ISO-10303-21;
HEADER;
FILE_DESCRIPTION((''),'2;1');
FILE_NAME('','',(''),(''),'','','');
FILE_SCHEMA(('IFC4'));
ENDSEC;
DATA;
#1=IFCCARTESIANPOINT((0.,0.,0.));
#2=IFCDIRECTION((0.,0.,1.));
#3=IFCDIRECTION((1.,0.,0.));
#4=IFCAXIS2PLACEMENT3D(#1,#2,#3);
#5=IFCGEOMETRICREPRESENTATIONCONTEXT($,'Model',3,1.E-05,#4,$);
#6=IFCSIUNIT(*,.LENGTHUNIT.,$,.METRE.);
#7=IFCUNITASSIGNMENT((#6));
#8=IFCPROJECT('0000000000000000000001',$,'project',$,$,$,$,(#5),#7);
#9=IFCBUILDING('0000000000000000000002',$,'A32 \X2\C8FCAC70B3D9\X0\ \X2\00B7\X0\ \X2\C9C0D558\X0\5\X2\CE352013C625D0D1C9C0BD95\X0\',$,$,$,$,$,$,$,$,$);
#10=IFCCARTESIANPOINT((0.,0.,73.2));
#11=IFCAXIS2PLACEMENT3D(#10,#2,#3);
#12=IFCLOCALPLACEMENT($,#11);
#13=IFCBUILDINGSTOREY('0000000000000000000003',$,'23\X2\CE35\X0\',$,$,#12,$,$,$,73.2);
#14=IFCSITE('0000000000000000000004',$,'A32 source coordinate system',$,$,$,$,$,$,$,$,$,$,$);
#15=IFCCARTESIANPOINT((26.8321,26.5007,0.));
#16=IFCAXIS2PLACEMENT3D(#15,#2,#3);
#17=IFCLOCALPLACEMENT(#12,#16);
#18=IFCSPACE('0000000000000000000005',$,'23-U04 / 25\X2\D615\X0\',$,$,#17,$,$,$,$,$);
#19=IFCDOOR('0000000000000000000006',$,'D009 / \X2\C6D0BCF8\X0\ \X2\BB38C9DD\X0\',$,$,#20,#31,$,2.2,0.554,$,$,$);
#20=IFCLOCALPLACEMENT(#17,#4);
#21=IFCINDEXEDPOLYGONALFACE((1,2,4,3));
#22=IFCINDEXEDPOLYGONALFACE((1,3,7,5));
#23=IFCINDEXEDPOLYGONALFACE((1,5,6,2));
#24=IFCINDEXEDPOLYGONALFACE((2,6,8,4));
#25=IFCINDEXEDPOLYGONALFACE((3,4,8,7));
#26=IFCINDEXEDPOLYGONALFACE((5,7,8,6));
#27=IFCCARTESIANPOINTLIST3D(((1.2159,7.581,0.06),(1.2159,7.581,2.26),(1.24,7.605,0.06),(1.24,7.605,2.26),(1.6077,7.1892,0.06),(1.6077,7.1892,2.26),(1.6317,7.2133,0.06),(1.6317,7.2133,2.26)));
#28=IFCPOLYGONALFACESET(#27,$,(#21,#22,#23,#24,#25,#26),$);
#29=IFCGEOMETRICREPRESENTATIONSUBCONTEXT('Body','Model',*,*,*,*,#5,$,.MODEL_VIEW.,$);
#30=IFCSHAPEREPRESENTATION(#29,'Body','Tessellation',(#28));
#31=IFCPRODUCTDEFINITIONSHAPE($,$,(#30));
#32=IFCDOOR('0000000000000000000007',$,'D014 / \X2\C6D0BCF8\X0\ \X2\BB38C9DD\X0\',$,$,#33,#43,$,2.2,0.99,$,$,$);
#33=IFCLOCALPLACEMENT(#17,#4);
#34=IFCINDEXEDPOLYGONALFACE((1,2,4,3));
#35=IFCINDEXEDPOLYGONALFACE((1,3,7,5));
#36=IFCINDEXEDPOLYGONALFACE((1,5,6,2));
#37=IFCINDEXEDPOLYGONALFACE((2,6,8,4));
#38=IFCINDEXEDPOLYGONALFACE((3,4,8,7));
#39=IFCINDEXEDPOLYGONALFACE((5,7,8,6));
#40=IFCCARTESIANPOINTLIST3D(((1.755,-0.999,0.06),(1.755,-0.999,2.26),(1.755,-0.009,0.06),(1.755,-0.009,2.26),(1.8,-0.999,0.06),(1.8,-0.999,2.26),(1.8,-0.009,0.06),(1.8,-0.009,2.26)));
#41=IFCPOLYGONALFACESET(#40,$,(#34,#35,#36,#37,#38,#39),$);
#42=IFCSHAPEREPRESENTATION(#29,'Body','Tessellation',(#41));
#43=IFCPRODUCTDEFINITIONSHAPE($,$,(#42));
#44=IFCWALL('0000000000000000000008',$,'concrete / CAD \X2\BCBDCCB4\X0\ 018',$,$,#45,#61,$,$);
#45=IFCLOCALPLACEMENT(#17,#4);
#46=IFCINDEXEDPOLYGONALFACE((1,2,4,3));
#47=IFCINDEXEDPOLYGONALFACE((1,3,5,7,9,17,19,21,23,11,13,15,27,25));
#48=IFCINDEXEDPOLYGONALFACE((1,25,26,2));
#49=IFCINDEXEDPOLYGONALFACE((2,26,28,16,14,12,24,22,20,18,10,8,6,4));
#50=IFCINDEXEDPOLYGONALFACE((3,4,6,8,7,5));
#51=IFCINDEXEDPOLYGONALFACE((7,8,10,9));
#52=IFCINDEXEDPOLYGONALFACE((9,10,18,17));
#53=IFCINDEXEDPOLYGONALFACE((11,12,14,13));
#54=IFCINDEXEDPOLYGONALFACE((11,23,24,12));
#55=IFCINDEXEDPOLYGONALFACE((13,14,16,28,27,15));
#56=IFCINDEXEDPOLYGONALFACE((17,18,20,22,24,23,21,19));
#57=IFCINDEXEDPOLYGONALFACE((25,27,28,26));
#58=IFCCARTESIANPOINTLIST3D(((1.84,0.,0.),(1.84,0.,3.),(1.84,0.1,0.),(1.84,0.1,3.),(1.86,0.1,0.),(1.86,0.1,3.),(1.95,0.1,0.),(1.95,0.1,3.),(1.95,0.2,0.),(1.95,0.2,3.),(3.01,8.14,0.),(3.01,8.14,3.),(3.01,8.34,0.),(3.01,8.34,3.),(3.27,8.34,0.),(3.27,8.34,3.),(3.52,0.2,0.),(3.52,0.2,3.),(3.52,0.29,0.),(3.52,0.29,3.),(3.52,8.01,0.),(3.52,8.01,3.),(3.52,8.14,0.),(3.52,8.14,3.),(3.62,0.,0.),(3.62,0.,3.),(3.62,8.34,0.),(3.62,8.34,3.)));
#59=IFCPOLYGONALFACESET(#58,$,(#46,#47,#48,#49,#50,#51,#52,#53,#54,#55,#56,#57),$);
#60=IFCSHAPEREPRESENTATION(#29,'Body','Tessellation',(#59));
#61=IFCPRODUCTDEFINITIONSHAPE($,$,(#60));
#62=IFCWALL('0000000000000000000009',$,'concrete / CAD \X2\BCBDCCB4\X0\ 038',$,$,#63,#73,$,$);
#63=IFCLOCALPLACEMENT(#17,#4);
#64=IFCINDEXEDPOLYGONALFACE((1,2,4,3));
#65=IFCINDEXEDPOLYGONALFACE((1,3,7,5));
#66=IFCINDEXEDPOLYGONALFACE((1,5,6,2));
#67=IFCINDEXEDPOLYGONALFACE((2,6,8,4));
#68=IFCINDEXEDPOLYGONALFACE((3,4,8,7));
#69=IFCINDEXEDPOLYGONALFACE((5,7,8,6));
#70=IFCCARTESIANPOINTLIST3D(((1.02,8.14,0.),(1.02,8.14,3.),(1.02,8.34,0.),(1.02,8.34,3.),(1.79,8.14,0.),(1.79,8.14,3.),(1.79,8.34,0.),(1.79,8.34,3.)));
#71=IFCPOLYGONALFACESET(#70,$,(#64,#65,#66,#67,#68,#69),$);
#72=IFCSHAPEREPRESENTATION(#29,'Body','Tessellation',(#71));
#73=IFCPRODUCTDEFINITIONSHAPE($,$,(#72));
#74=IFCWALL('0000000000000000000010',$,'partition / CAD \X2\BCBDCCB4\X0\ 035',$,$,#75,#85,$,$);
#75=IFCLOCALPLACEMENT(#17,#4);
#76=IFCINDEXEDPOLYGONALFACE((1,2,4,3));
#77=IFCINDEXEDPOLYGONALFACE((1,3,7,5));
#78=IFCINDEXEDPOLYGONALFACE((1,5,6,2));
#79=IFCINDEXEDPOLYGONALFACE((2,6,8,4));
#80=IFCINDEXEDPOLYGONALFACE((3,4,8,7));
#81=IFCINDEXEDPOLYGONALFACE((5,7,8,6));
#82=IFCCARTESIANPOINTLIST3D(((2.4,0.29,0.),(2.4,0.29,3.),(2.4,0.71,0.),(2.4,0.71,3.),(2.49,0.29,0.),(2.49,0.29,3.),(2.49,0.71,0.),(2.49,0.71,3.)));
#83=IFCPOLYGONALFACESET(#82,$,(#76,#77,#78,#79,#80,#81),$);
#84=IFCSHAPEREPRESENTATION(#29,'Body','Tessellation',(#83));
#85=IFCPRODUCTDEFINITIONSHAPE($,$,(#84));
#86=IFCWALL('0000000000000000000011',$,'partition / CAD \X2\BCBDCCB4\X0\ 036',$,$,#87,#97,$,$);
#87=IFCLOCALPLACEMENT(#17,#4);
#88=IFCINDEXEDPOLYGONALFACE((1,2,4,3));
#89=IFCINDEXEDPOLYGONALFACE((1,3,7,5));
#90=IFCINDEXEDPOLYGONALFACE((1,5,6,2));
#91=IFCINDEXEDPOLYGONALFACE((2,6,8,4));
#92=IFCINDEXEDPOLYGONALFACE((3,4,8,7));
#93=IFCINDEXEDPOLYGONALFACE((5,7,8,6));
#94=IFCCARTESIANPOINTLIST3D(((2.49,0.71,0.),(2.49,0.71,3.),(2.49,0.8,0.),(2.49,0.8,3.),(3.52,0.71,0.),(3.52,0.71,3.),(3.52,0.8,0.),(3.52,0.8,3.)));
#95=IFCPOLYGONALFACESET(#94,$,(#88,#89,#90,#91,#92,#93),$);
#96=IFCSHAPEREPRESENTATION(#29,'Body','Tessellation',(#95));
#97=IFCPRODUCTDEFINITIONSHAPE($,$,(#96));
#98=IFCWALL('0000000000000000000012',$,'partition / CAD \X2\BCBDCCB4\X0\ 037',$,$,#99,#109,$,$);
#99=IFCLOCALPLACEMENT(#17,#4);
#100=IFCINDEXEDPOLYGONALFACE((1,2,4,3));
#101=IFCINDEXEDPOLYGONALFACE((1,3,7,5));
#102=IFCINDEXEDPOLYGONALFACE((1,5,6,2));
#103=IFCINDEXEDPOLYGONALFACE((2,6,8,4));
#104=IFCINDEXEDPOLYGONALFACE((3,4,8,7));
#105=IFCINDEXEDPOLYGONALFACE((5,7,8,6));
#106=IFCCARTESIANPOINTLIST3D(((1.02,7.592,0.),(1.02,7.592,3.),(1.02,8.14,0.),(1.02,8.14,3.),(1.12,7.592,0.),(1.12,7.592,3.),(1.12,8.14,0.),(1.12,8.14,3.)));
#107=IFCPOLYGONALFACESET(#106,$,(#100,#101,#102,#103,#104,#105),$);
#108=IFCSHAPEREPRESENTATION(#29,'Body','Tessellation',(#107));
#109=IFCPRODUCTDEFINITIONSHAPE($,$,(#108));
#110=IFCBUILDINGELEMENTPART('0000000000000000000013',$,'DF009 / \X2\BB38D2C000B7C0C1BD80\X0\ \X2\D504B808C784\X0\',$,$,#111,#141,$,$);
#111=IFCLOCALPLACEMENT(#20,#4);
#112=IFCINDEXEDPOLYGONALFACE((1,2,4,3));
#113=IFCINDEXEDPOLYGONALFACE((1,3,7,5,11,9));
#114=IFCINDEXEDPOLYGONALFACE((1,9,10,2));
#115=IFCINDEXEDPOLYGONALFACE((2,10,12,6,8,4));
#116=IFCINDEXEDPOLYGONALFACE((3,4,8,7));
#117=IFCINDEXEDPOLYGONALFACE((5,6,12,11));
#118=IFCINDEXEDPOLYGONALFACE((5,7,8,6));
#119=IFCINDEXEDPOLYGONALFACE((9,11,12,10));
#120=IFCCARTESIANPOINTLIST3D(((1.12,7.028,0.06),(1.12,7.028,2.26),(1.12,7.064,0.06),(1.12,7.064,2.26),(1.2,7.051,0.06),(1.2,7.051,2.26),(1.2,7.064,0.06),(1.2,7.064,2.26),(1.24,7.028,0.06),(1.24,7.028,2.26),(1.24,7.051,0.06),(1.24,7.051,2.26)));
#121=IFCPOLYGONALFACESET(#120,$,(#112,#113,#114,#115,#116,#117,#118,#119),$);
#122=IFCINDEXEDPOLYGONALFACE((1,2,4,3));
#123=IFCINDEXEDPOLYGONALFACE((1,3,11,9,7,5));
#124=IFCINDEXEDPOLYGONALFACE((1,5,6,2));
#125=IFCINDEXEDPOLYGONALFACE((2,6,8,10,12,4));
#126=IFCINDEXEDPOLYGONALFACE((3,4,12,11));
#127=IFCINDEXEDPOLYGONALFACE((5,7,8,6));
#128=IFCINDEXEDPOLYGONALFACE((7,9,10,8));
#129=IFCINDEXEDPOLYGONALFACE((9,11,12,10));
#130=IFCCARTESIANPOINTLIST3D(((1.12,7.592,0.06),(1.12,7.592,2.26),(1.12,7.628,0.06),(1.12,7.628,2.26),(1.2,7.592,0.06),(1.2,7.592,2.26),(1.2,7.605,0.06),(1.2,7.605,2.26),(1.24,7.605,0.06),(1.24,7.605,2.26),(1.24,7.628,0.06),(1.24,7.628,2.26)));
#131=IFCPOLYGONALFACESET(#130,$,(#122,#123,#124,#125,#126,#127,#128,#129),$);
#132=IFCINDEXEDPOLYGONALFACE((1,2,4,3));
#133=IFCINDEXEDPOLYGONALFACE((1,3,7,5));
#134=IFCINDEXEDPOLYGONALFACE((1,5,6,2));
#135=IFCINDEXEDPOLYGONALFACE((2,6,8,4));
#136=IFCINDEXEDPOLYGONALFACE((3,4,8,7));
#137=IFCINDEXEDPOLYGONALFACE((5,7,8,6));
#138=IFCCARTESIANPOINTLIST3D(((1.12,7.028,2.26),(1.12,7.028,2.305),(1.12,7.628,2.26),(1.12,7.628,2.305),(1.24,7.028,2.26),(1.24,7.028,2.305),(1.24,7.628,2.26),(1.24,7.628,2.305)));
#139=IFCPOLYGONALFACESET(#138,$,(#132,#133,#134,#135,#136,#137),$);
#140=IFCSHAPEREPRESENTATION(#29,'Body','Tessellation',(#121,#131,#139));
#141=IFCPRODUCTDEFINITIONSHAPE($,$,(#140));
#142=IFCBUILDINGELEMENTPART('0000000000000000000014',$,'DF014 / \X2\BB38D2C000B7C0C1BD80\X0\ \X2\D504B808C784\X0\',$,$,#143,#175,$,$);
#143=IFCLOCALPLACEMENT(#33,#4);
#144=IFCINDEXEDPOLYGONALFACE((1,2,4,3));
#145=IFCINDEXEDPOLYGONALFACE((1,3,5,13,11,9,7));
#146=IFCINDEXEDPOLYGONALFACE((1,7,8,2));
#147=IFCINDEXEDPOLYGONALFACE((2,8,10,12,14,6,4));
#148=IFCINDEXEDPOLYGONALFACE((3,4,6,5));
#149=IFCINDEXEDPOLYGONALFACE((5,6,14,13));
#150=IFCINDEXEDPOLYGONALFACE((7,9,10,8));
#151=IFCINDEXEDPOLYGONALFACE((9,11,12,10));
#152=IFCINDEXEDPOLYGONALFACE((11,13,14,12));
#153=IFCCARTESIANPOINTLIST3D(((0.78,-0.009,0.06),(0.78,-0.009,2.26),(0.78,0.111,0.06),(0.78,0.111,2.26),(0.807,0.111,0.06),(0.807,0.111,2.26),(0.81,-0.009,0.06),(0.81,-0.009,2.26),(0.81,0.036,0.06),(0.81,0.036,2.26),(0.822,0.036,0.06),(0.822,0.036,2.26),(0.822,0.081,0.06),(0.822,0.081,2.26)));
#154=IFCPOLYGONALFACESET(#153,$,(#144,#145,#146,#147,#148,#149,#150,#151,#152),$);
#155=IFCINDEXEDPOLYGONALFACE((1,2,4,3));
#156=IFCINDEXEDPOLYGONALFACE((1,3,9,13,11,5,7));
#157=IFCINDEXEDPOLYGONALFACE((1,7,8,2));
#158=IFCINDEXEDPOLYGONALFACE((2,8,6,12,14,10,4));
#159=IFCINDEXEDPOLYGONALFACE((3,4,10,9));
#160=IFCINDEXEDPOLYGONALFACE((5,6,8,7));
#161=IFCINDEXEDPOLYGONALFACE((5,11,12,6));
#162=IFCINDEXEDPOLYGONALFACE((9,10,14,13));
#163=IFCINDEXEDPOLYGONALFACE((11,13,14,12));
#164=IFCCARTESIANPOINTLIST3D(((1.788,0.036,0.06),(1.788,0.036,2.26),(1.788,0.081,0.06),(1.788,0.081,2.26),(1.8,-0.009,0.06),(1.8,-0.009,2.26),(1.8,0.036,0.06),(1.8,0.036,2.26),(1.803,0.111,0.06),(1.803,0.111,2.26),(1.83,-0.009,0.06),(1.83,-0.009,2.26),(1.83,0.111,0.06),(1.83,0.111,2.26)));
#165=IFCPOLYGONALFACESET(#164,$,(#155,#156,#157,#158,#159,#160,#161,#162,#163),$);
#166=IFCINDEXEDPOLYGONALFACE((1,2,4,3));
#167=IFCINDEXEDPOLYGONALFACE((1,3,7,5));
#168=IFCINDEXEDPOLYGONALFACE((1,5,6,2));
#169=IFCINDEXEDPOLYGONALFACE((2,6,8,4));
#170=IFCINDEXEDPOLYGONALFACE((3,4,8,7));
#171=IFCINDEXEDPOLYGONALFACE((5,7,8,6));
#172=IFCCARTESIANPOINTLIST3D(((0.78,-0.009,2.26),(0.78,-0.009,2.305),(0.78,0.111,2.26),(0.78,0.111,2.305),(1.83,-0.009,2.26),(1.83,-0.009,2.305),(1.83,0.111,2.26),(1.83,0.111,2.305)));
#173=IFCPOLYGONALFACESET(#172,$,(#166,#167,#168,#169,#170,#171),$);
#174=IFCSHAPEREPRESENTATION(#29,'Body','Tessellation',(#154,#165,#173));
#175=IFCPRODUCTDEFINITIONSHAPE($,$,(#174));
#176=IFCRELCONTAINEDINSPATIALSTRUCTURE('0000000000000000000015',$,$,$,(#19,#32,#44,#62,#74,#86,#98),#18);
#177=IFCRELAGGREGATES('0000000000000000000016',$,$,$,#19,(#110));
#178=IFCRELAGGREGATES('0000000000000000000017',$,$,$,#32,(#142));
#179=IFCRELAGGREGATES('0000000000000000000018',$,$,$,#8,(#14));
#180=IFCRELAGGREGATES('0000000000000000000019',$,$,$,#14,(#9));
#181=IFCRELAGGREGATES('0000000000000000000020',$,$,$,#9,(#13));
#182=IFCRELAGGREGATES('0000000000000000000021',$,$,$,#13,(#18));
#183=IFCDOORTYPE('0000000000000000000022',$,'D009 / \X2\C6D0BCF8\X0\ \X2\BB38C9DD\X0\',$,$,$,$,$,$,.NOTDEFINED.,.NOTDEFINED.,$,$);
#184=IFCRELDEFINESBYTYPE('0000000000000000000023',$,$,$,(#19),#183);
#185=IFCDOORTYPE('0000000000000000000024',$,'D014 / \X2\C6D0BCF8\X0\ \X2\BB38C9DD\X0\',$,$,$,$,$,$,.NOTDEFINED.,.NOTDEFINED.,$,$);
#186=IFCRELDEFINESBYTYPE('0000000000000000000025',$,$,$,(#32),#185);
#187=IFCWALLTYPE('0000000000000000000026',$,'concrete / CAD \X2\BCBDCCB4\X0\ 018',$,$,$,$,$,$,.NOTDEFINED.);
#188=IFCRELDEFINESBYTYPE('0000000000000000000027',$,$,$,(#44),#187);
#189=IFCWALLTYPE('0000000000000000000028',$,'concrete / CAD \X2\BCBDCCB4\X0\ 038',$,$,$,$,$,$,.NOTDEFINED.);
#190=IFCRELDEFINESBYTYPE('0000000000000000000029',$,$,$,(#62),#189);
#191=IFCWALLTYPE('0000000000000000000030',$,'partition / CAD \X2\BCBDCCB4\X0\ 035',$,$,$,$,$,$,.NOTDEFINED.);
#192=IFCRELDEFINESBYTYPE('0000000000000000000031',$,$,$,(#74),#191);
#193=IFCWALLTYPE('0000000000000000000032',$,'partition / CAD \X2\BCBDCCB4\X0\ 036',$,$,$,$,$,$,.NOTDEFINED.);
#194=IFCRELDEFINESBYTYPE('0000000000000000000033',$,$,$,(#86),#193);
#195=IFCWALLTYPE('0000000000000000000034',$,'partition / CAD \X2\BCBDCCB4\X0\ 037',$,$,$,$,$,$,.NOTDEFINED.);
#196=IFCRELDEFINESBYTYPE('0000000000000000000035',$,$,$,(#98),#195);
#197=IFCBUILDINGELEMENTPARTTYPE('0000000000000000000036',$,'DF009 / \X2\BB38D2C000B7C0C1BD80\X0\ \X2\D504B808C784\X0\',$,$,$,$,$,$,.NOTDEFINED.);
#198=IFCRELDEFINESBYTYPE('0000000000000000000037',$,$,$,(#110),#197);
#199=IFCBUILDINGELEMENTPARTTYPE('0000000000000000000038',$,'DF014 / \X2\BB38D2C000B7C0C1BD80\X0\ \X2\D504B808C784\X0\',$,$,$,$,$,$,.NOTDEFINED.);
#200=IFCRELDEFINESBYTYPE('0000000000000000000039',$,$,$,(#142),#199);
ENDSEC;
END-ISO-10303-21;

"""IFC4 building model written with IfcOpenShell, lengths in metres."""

from ifc_helpers import new_model, si_unit, frame, origin, origin_with_axes, place, context, subcontext, project, spatial, polyline, outline, extrude, source, transform, mapped, type_object, type_shapes, element, aggregate, save


model = new_model("IFC4")

# Units and contexts
model_context = context("Model", 3, precision=1e-05, world=origin_with_axes())
body_context = subcontext(model_context, "Body", "Model", "MODEL_VIEW")
ifc_project = project(units=[si_unit("LENGTHUNIT", "METRE")], contexts=[model_context])

# Site, building, storey, space
storey_placement = place(None, frame((0.0, 0.0, 73.2), z_axis=(0.0, 0.0, 1.0), x_axis=(1.0, 0.0, 0.0)))
space_placement = place(storey_placement, frame((26.8321, 26.5007, 0.0), z_axis=(0.0, 0.0, 1.0), x_axis=(1.0, 0.0, 0.0)))
site = spatial("IfcSite", under=ifc_project, Name="A32 source coordinate system")
building = spatial("IfcBuilding", under=site, Name="A32 주거동 · 지하5층–옥탑지붕")
storey = spatial("IfcBuildingStorey", under=building, at=storey_placement, Name="23층", Elevation=73.2)
space = spatial("IfcSpace", under=storey, at=space_placement, Name="23-U04 / 25형")

# Doors
door_type_1 = type_object("IfcDoorType", Name="D009 / 원본 문짝", OperationType="NOTDEFINED", PredefinedType="NOTDEFINED")
shared_shape_1 = source(origin(), body_context, "Body", "SweptSolid", [
    extrude(outline(polyline([(1.24, 7.605), (1.6317, 7.2133), (1.6077, 7.1892), (1.2159, 7.581), (1.24, 7.605)])), frame((0.0, 0.0, 0.06)), (0.0, 0.0, 1.0), 2.2),
])
type_shapes(door_type_1, [shared_shape_1])
door_1_placement = place(space_placement, origin_with_axes())
door_1 = element("IfcDoor", 1, at=door_1_placement, inside=space, type_object=door_type_1, Name="D009 / 원본 문짝", OverallHeight=2.2, OverallWidth=0.554, context=body_context, shape_type="MappedRepresentation", body=[
    mapped(shared_shape_1, transform((0.0, 0.0, 0.0), scale=1.0)),
])
door_type_2 = type_object("IfcDoorType", Name="D014 / 원본 문짝", OperationType="NOTDEFINED", PredefinedType="NOTDEFINED")
shared_shape_2 = source(origin(), body_context, "Body", "SweptSolid", [
    extrude(outline(polyline([(1.8, -0.009), (1.8, -0.999), (1.755, -0.999), (1.755, -0.009), (1.8, -0.009)])), frame((0.0, 0.0, 0.06)), (0.0, 0.0, 1.0), 2.2),
])
type_shapes(door_type_2, [shared_shape_2])
door_2_placement = place(space_placement, origin_with_axes())
door_2 = element("IfcDoor", 2, at=door_2_placement, inside=space, type_object=door_type_2, Name="D014 / 원본 문짝", OverallHeight=2.2, OverallWidth=0.99, context=body_context, shape_type="MappedRepresentation", body=[
    mapped(shared_shape_2, transform((0.0, 0.0, 0.0), scale=1.0)),
])

# Walls
wall_type_1 = type_object("IfcWallType", Name="concrete / CAD 벽체 018", PredefinedType="NOTDEFINED")
shared_shape_3 = source(origin(), body_context, "Body", "SweptSolid", [
    extrude(outline(polyline([(3.27, 8.34), (3.27, 8.34), (3.62, 8.34), (3.62, 0.0), (1.84, 0.0), (1.84, 0.1), (1.86, 0.1), (1.95, 0.1), (1.95, 0.2), (3.52, 0.2), (3.52, 0.29), (3.52, 8.01), (3.52, 8.14), (3.01, 8.14), (3.01, 8.34), (3.27, 8.34)])), origin(), (0.0, 0.0, 1.0), 3.0),
])
type_shapes(wall_type_1, [shared_shape_3])
wall_1_placement = place(space_placement, origin_with_axes())
element("IfcWall", 3, at=wall_1_placement, inside=space, type_object=wall_type_1, Name="concrete / CAD 벽체 018", context=body_context, shape_type="MappedRepresentation", body=[
    mapped(shared_shape_3, transform((0.0, 0.0, 0.0), scale=1.0)),
])
wall_type_2 = type_object("IfcWallType", Name="concrete / CAD 벽체 038", PredefinedType="NOTDEFINED")
shared_shape_4 = source(origin(), body_context, "Body", "SweptSolid", [
    extrude(outline(polyline([(1.02, 8.14), (1.02, 8.34), (1.79, 8.34), (1.79, 8.14), (1.02, 8.14)])), origin(), (0.0, 0.0, 1.0), 3.0),
])
type_shapes(wall_type_2, [shared_shape_4])
wall_2_placement = place(space_placement, origin_with_axes())
element("IfcWall", 4, at=wall_2_placement, inside=space, type_object=wall_type_2, Name="concrete / CAD 벽체 038", context=body_context, shape_type="MappedRepresentation", body=[
    mapped(shared_shape_4, transform((0.0, 0.0, 0.0), scale=1.0)),
])
wall_type_3 = type_object("IfcWallType", Name="partition / CAD 벽체 035", PredefinedType="NOTDEFINED")
shared_shape_5 = source(origin(), body_context, "Body", "SweptSolid", [
    extrude(outline(polyline([(2.49, 0.71), (2.49, 0.29), (2.4, 0.29), (2.4, 0.71), (2.49, 0.71)])), origin(), (0.0, 0.0, 1.0), 3.0),
])
type_shapes(wall_type_3, [shared_shape_5])
wall_3_placement = place(space_placement, origin_with_axes())
element("IfcWall", 5, at=wall_3_placement, inside=space, type_object=wall_type_3, Name="partition / CAD 벽체 035", context=body_context, shape_type="MappedRepresentation", body=[
    mapped(shared_shape_5, transform((0.0, 0.0, 0.0), scale=1.0)),
])
wall_type_4 = type_object("IfcWallType", Name="partition / CAD 벽체 036", PredefinedType="NOTDEFINED")
shared_shape_6 = source(origin(), body_context, "Body", "SweptSolid", [
    extrude(outline(polyline([(2.49, 0.8), (3.52, 0.8), (3.52, 0.71), (2.49, 0.71), (2.49, 0.8)])), origin(), (0.0, 0.0, 1.0), 3.0),
])
type_shapes(wall_type_4, [shared_shape_6])
wall_4_placement = place(space_placement, origin_with_axes())
element("IfcWall", 6, at=wall_4_placement, inside=space, type_object=wall_type_4, Name="partition / CAD 벽체 036", context=body_context, shape_type="MappedRepresentation", body=[
    mapped(shared_shape_6, transform((0.0, 0.0, 0.0), scale=1.0)),
])
wall_type_5 = type_object("IfcWallType", Name="partition / CAD 벽체 037", PredefinedType="NOTDEFINED")
shared_shape_7 = source(origin(), body_context, "Body", "SweptSolid", [
    extrude(outline(polyline([(1.02, 7.592), (1.02, 8.14), (1.12, 8.14), (1.12, 7.592), (1.02, 7.592)])), origin(), (0.0, 0.0, 1.0), 3.0),
])
type_shapes(wall_type_5, [shared_shape_7])
wall_5_placement = place(space_placement, origin_with_axes())
element("IfcWall", 7, at=wall_5_placement, inside=space, type_object=wall_type_5, Name="partition / CAD 벽체 037", context=body_context, shape_type="MappedRepresentation", body=[
    mapped(shared_shape_7, transform((0.0, 0.0, 0.0), scale=1.0)),
])

# Building element parts
building_element_part_type_1 = type_object("IfcBuildingElementPartType", Name="DF009 / 문틀·상부 프레임", PredefinedType="NOTDEFINED")
shared_shape_8 = source(origin(), body_context, "Body", "SweptSolid", [
    extrude(outline(polyline([(1.12, 7.064), (1.2, 7.064), (1.2, 7.051), (1.24, 7.051), (1.24, 7.028), (1.12, 7.028), (1.12, 7.064)])), frame((0.0, 0.0, 0.06)), (0.0, 0.0, 1.0), 2.2),
    extrude(outline(polyline([(1.24, 7.628), (1.24, 7.605), (1.2, 7.605), (1.2, 7.592), (1.12, 7.592), (1.12, 7.628), (1.24, 7.628)])), frame((0.0, 0.0, 0.06)), (0.0, 0.0, 1.0), 2.2),
    extrude(outline(polyline([(1.12, 7.028), (1.12, 7.628), (1.24, 7.628), (1.24, 7.028), (1.12, 7.028)])), frame((0.0, 0.0, 2.26)), (0.0, 0.0, 1.0), 0.045),
])
type_shapes(building_element_part_type_1, [shared_shape_8])
building_element_part_1_placement = place(door_1_placement, origin_with_axes())
building_element_part_1 = element("IfcBuildingElementPart", 8, at=building_element_part_1_placement, type_object=building_element_part_type_1, Name="DF009 / 문틀·상부 프레임", context=body_context, shape_type="MappedRepresentation", body=[
    mapped(shared_shape_8, transform((0.0, 0.0, 0.0), scale=1.0)),
])
aggregate(door_1, [building_element_part_1])
building_element_part_type_2 = type_object("IfcBuildingElementPartType", Name="DF014 / 문틀·상부 프레임", PredefinedType="NOTDEFINED")
shared_shape_9 = source(origin(), body_context, "Body", "SweptSolid", [
    extrude(outline(polyline([(0.78, 0.111), (0.807, 0.111), (0.822, 0.081), (0.822, 0.036), (0.81, 0.036), (0.81, -0.009), (0.78, -0.009), (0.78, 0.111)])), frame((0.0, 0.0, 0.06)), (0.0, 0.0, 1.0), 2.2),
    extrude(outline(polyline([(1.8, -0.009), (1.8, 0.036), (1.788, 0.036), (1.788, 0.081), (1.803, 0.111), (1.83, 0.111), (1.83, -0.009), (1.8, -0.009)])), frame((0.0, 0.0, 0.06)), (0.0, 0.0, 1.0), 2.2),
    extrude(outline(polyline([(0.78, -0.009), (0.78, 0.111), (1.83, 0.111), (1.83, -0.009), (0.78, -0.009)])), frame((0.0, 0.0, 2.26)), (0.0, 0.0, 1.0), 0.045),
])
type_shapes(building_element_part_type_2, [shared_shape_9])
building_element_part_2_placement = place(door_2_placement, origin_with_axes())
building_element_part_2 = element("IfcBuildingElementPart", 9, at=building_element_part_2_placement, type_object=building_element_part_type_2, Name="DF014 / 문틀·상부 프레임", context=body_context, shape_type="MappedRepresentation", body=[
    mapped(shared_shape_9, transform((0.0, 0.0, 0.0), scale=1.0)),
])
aggregate(door_2, [building_element_part_2])

save(model, "model.ifc")
